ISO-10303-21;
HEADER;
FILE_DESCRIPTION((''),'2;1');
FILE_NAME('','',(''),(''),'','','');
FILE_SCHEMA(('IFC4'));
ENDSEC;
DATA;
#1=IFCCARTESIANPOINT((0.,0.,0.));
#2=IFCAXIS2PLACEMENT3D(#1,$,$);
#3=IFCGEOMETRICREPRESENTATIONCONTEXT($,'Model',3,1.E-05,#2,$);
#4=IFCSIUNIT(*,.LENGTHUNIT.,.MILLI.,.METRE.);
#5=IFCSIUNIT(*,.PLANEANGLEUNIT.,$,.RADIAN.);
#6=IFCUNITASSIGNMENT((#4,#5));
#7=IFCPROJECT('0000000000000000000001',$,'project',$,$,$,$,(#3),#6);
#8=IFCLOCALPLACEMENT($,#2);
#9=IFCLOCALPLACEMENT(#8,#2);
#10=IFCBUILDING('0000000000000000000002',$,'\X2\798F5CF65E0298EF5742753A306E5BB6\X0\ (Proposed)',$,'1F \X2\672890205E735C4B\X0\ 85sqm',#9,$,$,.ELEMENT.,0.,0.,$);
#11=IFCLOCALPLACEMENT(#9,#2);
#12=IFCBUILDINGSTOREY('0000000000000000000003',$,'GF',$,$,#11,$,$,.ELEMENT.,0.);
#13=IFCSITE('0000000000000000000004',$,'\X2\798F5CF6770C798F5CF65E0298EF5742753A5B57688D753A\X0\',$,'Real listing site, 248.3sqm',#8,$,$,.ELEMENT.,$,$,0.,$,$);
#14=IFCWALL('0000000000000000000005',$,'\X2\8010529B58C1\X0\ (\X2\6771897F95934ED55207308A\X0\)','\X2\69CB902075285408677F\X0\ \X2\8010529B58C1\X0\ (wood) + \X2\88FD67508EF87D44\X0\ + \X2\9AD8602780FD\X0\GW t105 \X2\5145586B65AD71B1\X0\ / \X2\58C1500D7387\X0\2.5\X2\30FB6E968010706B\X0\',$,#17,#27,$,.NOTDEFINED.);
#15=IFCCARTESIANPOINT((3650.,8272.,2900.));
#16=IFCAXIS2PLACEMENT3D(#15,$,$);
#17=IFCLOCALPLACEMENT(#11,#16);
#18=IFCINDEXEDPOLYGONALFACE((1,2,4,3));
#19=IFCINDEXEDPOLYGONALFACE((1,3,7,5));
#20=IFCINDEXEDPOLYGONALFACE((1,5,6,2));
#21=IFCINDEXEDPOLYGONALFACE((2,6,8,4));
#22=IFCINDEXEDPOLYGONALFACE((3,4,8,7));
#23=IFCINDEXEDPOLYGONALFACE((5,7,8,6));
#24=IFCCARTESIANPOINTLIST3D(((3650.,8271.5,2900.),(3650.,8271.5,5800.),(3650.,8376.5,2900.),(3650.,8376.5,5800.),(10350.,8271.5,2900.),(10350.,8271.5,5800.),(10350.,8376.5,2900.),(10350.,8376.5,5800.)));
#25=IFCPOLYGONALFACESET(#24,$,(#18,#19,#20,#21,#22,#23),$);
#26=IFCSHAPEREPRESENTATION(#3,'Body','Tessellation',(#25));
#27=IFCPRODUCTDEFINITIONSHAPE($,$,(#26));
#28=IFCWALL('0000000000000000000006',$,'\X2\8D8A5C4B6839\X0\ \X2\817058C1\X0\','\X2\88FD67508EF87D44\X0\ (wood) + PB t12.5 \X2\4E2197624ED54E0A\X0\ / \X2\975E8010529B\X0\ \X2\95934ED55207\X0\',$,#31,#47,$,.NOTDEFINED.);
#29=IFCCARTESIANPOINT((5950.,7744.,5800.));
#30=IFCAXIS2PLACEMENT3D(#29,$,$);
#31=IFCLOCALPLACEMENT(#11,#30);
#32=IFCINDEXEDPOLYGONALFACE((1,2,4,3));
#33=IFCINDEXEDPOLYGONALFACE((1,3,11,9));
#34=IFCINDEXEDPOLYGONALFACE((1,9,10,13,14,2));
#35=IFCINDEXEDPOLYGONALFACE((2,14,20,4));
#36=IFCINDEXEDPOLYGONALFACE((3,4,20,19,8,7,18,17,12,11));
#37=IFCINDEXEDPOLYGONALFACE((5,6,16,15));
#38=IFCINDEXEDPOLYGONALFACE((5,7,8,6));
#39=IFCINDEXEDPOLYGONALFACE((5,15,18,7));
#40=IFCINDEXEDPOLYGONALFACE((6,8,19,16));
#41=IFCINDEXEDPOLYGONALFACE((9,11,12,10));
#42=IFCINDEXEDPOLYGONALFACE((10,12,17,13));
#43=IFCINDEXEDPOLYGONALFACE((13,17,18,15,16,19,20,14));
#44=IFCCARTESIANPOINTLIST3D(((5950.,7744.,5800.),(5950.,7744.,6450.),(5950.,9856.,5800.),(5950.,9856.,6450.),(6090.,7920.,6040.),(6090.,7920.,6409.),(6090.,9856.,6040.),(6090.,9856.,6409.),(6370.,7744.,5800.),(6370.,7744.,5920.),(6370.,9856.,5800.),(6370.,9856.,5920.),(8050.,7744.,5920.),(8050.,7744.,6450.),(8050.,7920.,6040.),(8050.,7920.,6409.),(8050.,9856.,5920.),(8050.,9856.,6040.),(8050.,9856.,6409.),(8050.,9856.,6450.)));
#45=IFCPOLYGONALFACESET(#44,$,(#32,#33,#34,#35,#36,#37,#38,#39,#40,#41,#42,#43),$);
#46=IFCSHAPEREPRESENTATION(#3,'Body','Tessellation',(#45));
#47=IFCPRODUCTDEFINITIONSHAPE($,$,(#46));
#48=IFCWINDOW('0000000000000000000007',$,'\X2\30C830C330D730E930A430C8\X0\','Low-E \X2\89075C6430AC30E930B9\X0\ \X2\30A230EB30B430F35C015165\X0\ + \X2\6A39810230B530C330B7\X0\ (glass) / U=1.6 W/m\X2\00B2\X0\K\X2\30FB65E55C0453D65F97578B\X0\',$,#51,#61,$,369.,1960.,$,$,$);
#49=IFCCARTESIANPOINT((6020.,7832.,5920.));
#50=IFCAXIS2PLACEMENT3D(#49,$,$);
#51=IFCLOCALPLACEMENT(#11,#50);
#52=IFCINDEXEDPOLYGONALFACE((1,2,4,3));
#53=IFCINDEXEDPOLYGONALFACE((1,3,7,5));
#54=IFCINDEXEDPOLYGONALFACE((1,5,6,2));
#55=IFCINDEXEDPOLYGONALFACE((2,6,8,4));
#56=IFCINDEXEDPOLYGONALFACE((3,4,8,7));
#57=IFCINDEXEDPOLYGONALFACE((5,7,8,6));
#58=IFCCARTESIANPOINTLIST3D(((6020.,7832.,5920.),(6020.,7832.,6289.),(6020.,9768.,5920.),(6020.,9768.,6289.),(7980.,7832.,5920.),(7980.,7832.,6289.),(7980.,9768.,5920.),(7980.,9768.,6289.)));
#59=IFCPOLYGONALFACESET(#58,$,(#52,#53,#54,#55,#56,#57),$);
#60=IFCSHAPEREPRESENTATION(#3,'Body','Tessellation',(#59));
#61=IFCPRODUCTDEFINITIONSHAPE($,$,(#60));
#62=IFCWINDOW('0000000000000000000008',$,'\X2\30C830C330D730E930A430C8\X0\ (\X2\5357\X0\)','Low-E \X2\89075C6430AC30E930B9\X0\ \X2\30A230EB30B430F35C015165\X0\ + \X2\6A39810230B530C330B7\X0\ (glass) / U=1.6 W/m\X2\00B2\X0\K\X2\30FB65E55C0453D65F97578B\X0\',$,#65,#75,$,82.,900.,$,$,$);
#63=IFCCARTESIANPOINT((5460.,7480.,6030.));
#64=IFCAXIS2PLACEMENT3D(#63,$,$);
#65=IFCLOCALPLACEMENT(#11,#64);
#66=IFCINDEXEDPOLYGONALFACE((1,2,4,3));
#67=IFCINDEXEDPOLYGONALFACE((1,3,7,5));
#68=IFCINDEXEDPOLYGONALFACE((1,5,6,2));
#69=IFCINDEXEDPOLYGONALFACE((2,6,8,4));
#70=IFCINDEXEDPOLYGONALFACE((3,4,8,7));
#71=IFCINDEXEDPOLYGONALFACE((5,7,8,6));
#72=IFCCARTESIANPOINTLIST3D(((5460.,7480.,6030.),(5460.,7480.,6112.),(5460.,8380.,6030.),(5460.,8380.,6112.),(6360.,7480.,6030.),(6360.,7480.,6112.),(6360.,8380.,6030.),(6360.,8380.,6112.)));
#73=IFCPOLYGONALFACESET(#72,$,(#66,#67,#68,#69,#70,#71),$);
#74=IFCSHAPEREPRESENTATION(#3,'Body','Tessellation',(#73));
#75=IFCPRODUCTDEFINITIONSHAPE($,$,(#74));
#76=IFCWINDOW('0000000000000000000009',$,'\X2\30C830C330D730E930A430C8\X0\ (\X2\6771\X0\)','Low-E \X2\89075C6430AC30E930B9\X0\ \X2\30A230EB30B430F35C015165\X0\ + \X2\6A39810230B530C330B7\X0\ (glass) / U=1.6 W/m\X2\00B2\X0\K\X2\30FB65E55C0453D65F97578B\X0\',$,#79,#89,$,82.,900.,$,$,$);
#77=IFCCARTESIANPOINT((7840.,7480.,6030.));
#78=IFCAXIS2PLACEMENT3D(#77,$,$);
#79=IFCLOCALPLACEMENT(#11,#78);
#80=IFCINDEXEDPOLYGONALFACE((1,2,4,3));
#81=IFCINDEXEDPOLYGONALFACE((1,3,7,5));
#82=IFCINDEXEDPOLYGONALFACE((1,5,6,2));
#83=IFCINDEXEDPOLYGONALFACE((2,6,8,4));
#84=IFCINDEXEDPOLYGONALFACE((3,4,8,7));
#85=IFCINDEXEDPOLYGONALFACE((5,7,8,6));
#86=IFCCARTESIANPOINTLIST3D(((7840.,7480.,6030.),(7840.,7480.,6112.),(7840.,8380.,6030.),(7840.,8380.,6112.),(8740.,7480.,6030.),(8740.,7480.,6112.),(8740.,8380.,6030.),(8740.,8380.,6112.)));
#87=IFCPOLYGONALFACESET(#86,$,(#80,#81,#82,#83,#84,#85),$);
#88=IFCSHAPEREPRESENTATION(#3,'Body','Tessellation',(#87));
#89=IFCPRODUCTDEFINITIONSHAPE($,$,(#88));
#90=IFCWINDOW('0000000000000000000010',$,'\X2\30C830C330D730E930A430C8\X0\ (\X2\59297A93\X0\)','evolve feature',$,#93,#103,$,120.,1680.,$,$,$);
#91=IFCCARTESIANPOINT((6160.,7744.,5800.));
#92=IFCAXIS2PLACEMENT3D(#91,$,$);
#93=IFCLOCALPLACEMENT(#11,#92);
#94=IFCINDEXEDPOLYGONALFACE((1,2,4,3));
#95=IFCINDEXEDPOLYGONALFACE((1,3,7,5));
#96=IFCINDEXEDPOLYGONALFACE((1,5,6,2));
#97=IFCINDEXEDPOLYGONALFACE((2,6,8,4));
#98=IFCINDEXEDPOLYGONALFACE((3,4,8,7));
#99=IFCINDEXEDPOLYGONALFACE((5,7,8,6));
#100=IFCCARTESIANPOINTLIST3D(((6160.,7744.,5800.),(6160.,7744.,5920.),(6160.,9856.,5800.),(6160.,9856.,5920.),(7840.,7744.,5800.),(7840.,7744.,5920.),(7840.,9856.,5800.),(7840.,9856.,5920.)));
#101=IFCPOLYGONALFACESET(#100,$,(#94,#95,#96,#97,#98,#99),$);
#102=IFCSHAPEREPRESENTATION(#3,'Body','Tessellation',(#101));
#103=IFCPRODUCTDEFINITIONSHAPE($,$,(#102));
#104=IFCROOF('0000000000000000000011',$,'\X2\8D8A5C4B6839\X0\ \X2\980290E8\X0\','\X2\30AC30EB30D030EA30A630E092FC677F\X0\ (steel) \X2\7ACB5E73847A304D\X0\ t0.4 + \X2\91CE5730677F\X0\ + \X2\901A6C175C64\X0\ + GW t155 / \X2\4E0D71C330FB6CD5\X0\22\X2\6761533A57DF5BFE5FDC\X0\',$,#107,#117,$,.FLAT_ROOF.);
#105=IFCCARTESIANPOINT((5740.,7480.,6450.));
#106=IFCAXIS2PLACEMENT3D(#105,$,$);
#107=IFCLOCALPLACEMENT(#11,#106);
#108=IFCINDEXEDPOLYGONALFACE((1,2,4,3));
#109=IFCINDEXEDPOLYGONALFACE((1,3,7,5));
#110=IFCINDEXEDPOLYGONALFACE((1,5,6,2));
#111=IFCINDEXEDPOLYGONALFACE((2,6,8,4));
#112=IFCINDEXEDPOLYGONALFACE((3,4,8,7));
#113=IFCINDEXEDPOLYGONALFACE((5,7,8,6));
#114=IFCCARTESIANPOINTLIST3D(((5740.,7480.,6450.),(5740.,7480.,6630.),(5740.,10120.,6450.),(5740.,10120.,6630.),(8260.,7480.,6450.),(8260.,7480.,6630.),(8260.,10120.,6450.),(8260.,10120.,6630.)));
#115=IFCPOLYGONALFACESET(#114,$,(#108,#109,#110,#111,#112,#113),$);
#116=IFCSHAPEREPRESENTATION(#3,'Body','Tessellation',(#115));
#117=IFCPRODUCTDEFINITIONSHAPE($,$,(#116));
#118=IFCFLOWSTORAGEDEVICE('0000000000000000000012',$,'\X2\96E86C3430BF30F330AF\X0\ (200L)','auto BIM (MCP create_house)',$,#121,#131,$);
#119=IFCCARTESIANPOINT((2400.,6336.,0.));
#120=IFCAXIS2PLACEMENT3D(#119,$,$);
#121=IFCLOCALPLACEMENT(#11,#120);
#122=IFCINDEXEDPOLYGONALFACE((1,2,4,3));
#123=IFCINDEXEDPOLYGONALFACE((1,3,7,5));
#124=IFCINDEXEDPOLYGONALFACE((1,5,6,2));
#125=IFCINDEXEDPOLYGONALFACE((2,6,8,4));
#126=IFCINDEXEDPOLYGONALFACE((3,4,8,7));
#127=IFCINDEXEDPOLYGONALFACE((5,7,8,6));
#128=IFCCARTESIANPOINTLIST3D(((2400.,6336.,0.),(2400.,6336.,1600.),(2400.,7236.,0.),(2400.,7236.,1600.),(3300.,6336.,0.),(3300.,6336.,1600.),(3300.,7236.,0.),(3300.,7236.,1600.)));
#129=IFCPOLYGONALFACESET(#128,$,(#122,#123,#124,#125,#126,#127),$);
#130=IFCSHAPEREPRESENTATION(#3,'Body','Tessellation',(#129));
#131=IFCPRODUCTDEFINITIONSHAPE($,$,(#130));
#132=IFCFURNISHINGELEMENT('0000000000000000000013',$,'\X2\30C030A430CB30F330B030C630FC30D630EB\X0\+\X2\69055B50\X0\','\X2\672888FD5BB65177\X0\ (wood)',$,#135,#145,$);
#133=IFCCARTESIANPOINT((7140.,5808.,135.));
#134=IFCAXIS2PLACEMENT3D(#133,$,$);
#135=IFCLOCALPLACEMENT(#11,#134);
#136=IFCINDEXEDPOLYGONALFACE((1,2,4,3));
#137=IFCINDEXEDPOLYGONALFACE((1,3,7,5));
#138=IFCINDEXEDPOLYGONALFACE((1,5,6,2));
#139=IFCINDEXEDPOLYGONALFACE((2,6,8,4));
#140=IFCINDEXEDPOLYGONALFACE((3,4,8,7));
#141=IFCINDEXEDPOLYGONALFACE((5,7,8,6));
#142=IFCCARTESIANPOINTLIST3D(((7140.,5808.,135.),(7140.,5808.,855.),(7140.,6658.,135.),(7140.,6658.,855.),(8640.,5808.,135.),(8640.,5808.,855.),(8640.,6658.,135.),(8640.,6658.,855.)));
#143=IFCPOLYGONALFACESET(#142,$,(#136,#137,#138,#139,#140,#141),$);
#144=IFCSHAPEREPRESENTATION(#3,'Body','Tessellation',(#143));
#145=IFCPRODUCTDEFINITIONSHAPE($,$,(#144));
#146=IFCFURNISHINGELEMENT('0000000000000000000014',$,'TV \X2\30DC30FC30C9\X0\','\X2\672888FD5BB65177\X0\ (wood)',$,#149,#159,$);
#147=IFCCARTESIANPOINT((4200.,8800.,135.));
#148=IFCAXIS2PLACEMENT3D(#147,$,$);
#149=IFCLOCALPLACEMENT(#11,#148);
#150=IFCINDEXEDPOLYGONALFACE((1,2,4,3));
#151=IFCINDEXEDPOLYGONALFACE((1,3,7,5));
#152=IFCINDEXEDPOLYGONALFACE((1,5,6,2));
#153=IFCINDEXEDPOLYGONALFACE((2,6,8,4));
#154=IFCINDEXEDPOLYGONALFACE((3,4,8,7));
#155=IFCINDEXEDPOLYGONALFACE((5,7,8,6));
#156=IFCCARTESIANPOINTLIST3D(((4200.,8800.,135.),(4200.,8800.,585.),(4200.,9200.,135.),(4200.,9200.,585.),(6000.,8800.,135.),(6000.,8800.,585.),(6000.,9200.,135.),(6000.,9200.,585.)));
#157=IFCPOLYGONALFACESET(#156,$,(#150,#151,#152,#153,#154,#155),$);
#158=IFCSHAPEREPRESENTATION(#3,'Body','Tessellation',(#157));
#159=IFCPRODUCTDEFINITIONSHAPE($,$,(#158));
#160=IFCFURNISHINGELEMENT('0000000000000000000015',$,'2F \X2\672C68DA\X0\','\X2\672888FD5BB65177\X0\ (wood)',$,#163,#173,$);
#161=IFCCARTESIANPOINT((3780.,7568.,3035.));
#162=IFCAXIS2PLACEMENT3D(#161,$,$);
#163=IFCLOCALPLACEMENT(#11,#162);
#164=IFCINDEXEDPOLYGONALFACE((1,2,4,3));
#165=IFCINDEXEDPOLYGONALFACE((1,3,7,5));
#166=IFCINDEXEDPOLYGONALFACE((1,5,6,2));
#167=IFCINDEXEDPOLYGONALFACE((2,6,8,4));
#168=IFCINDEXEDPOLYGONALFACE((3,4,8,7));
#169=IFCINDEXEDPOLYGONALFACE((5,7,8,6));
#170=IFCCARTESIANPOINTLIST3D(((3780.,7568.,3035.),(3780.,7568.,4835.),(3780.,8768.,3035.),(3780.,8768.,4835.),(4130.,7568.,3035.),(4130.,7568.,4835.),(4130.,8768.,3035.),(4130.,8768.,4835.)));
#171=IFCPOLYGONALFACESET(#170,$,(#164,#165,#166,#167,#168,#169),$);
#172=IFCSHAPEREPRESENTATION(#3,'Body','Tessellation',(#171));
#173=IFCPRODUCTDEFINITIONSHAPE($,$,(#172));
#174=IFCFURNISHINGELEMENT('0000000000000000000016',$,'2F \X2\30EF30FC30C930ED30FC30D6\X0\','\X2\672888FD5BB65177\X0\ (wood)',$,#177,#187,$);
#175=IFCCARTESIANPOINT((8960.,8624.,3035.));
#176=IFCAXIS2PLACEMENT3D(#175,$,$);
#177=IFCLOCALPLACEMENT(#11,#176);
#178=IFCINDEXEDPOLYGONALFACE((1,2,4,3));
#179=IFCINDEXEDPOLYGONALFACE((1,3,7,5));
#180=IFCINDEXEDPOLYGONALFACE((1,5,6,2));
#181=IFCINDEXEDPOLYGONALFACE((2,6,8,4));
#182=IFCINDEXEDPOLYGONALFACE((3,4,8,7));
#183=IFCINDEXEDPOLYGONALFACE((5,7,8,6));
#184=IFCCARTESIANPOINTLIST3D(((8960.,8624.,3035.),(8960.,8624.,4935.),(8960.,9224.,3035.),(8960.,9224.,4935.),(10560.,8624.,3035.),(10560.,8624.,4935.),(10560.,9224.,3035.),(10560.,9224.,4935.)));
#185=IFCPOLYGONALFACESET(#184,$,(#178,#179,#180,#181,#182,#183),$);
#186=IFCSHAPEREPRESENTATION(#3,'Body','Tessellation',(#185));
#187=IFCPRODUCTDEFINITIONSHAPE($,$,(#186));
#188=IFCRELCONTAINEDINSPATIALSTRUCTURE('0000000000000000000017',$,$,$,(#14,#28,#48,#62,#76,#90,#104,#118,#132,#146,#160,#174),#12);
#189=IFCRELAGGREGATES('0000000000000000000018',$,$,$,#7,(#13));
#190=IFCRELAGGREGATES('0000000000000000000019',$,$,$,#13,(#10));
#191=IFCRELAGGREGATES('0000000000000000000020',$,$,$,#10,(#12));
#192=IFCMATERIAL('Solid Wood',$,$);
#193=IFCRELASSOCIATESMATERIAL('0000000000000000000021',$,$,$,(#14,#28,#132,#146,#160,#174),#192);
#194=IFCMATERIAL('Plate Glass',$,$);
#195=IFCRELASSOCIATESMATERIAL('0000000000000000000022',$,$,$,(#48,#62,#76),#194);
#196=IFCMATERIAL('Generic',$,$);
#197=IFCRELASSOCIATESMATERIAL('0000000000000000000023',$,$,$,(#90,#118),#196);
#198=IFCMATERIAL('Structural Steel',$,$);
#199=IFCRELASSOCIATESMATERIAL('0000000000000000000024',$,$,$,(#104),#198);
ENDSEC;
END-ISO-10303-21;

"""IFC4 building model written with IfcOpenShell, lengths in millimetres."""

from ifc_helpers import new_model, si_unit, frame, frame_2d, origin, place, context, project, spatial, rectangle, extrude, material, element, fill, save


model = new_model("IFC4")

# Units and contexts
model_context = context("Model", 3, precision=1e-05, world=origin())
ifc_project = project(units=[si_unit("LENGTHUNIT", "METRE", prefix="MILLI"), si_unit("PLANEANGLEUNIT", "RADIAN")], contexts=[model_context])

# Site, building, storey
site_placement = place(None, origin())
site = spatial("IfcSite", under=ifc_project, at=site_placement, Name="福島県福島市飯坂町字梍町", ObjectType="Real listing site, 248.3sqm", CompositionType="ELEMENT", RefElevation=0.0)
building_placement = place(site_placement, origin())
building = spatial("IfcBuilding", under=site, at=building_placement, Name="福島市飯坂町の家 (Proposed)", ObjectType="1F 木造平屋 85sqm", CompositionType="ELEMENT", ElevationOfRefHeight=0.0, ElevationOfTerrain=0.0)
storey_placement = place(building_placement, origin())
storey = spatial("IfcBuildingStorey", under=building, at=storey_placement, Name="GF", CompositionType="ELEMENT", Elevation=0.0)

# Wall
ifc_material_1 = material(Name="Solid Wood")
wall_1_placement = place(storey_placement, frame((3650.0, 8272.0, 2900.0)))
element("IfcWall", 1, at=wall_1_placement, inside=storey, material=ifc_material_1, Name="耐力壁 (東西間仕切り)", Description="構造用合板 耐力壁 (wood) + 製材軸組 + 高性能GW t105 充填断熱 / 壁倍率2.5・準耐火", PredefinedType="NOTDEFINED", context=model_context, shape_type="SweptSolid", body=[
    extrude(rectangle(XDim=6700.0, YDim=105.0, at=frame_2d((3350.0, 52.0))), frame((3650.0, 8272.0, 2900.0)), (0.0, 0.0, 1.0), 2900.0),
])

# Wall, openings, windows
wall_2_placement = place(storey_placement, frame((5950.0, 7744.0, 5800.0)))
wall_2 = element("IfcWall", 2, at=wall_2_placement, inside=storey, material=ifc_material_1, Name="越屋根 腰壁", Description="製材軸組 (wood) + PB t12.5 両面仕上 / 非耐力 間仕切", PredefinedType="NOTDEFINED", context=model_context, shape_type="SweptSolid", body=[
    extrude(rectangle(XDim=2100.0, YDim=2112.0, at=frame_2d((1050.0, 1056.0))), frame((5950.0, 7744.0, 5800.0)), (0.0, 0.0, 1.0), 650.0),
])
opening_1_placement = place(storey_placement, frame((6020.0, 7832.0, 5920.0)))
opening_1 = element("IfcOpeningElement", 3, at=opening_1_placement, cuts=wall_2, PredefinedType="NOTDEFINED", context=model_context, shape_type="SweptSolid", body=[
    extrude(rectangle(XDim=1960.0, YDim=1936.0, at=frame_2d((980.0, 968.0))), frame((6020.0, 7832.0, 5920.0)), (0.0, 0.0, 1.0), 369.0),
])
opening_2_placement = place(storey_placement, frame((5460.0, 7480.0, 6030.0)))
opening_2 = element("IfcOpeningElement", 4, at=opening_2_placement, cuts=wall_2, PredefinedType="NOTDEFINED", context=model_context, shape_type="SweptSolid", body=[
    extrude(rectangle(XDim=900.0, YDim=900.0, at=frame_2d((450.0, 450.0))), frame((5460.0, 7480.0, 6030.0)), (0.0, 0.0, 1.0), 82.0),
])
opening_3_placement = place(storey_placement, frame((7840.0, 7480.0, 6030.0)))
opening_3 = element("IfcOpeningElement", 5, at=opening_3_placement, cuts=wall_2, PredefinedType="NOTDEFINED", context=model_context, shape_type="SweptSolid", body=[
    extrude(rectangle(XDim=900.0, YDim=900.0, at=frame_2d((450.0, 450.0))), frame((7840.0, 7480.0, 6030.0)), (0.0, 0.0, 1.0), 82.0),
])
opening_4_placement = place(storey_placement, frame((6160.0, 7744.0, 5800.0)))
opening_4 = element("IfcOpeningElement", 6, at=opening_4_placement, cuts=wall_2, PredefinedType="NOTDEFINED", context=model_context, shape_type="SweptSolid", body=[
    extrude(rectangle(XDim=1680.0, YDim=2112.0, at=frame_2d((840.0, 1056.0))), frame((6160.0, 7744.0, 5800.0)), (0.0, 0.0, 1.0), 120.0),
])
ifc_material_2 = material(Name="Plate Glass")
window_1_placement = place(storey_placement, frame((6020.0, 7832.0, 5920.0)))
window_1 = element("IfcWindow", 7, at=window_1_placement, inside=storey, material=ifc_material_2, Name="トップライト", Description="Low-E 複層ガラス アルゴン封入 + 樹脂サッシ (glass) / U=1.6 W/m²K・日射取得型", OverallHeight=369.0, OverallWidth=1960.0, context=model_context, shape_type="SweptSolid", body=[
    extrude(rectangle(XDim=1960.0, YDim=1936.0, at=frame_2d((980.0, 968.0))), frame((6020.0, 7832.0, 5920.0)), (0.0, 0.0, 1.0), 369.0),
])
fill(opening_1, window_1)
window_2_placement = place(storey_placement, frame((5460.0, 7480.0, 6030.0)))
window_2 = element("IfcWindow", 8, at=window_2_placement, inside=storey, material=ifc_material_2, Name="トップライト (南)", Description="Low-E 複層ガラス アルゴン封入 + 樹脂サッシ (glass) / U=1.6 W/m²K・日射取得型", OverallHeight=82.0, OverallWidth=900.0, context=model_context, shape_type="SweptSolid", body=[
    extrude(rectangle(XDim=900.0, YDim=900.0, at=frame_2d((450.0, 450.0))), frame((5460.0, 7480.0, 6030.0)), (0.0, 0.0, 1.0), 82.0),
])
fill(opening_2, window_2)
window_3_placement = place(storey_placement, frame((7840.0, 7480.0, 6030.0)))
window_3 = element("IfcWindow", 9, at=window_3_placement, inside=storey, material=ifc_material_2, Name="トップライト (東)", Description="Low-E 複層ガラス アルゴン封入 + 樹脂サッシ (glass) / U=1.6 W/m²K・日射取得型", OverallHeight=82.0, OverallWidth=900.0, context=model_context, shape_type="SweptSolid", body=[
    extrude(rectangle(XDim=900.0, YDim=900.0, at=frame_2d((450.0, 450.0))), frame((7840.0, 7480.0, 6030.0)), (0.0, 0.0, 1.0), 82.0),
])
fill(opening_3, window_3)
ifc_material_3 = material(Name="Generic")
window_4_placement = place(storey_placement, frame((6160.0, 7744.0, 5800.0)))
window_4 = element("IfcWindow", 10, at=window_4_placement, inside=storey, material=ifc_material_3, Name="トップライト (天窓)", Description="evolve feature", OverallHeight=120.0, OverallWidth=1680.0, context=model_context, shape_type="SweptSolid", body=[
    extrude(rectangle(XDim=1680.0, YDim=2112.0, at=frame_2d((840.0, 1056.0))), frame((6160.0, 7744.0, 5800.0)), (0.0, 0.0, 1.0), 120.0),
])
fill(opening_4, window_4)

# Roof
ifc_material_4 = material(Name="Structural Steel")
roof_placement = place(storey_placement, frame((5740.0, 7480.0, 6450.0)))
element("IfcRoof", 11, at=roof_placement, inside=storey, material=ifc_material_4, Name="越屋根 頂部", Description="ガルバリウム鋼板 (steel) 立平葺き t0.4 + 野地板 + 通気層 + GW t155 / 不燃・法22条区域対応", PredefinedType="FLAT_ROOF", context=model_context, shape_type="SweptSolid", body=[
    extrude(rectangle(XDim=2520.0, YDim=2640.0, at=frame_2d((1260.0, 1320.0))), frame((5740.0, 7480.0, 6450.0)), (0.0, 0.0, 1.0), 180.0),
])

# Flow storage device
flow_storage_device_placement = place(storey_placement, frame((2400.0, 6336.0, 0.0)))
element("IfcFlowStorageDevice", 12, at=flow_storage_device_placement, inside=storey, material=ifc_material_3, Name="雨水タンク (200L)", Description="auto BIM (MCP create_house)", context=model_context, shape_type="SweptSolid", body=[
    extrude(rectangle(XDim=900.0, YDim=900.0, at=frame_2d((450.0, 450.0))), frame((2400.0, 6336.0, 0.0)), (0.0, 0.0, 1.0), 1600.0),
])

# Furnishing elements
furnishing_1_placement = place(storey_placement, frame((7140.0, 5808.0, 135.0)))
element("IfcFurnishingElement", 13, at=furnishing_1_placement, inside=storey, material=ifc_material_1, Name="ダイニングテーブル+椅子", Description="木製家具 (wood)", context=model_context, shape_type="SweptSolid", body=[
    extrude(rectangle(XDim=1500.0, YDim=850.0, at=frame_2d((750.0, 425.0))), frame((7140.0, 5808.0, 135.0)), (0.0, 0.0, 1.0), 720.0),
])
furnishing_2_placement = place(storey_placement, frame((4200.0, 8800.0, 135.0)))
element("IfcFurnishingElement", 14, at=furnishing_2_placement, inside=storey, material=ifc_material_1, Name="TV ボード", Description="木製家具 (wood)", context=model_context, shape_type="SweptSolid", body=[
    extrude(rectangle(XDim=1800.0, YDim=400.0, at=frame_2d((900.0, 200.0))), frame((4200.0, 8800.0, 135.0)), (0.0, 0.0, 1.0), 450.0),
])
furnishing_3_placement = place(storey_placement, frame((3780.0, 7568.0, 3035.0)))
element("IfcFurnishingElement", 15, at=furnishing_3_placement, inside=storey, material=ifc_material_1, Name="2F 本棚", Description="木製家具 (wood)", context=model_context, shape_type="SweptSolid", body=[
    extrude(rectangle(XDim=350.0, YDim=1200.0, at=frame_2d((175.0, 600.0))), frame((3780.0, 7568.0, 3035.0)), (0.0, 0.0, 1.0), 1800.0),
])
furnishing_4_placement = place(storey_placement, frame((8960.0, 8624.0, 3035.0)))
element("IfcFurnishingElement", 16, at=furnishing_4_placement, inside=storey, material=ifc_material_1, Name="2F ワードローブ", Description="木製家具 (wood)", context=model_context, shape_type="SweptSolid", body=[
    extrude(rectangle(XDim=1600.0, YDim=600.0, at=frame_2d((800.0, 300.0))), frame((8960.0, 8624.0, 3035.0)), (0.0, 0.0, 1.0), 1900.0),
])

save(model, "model.ifc")
